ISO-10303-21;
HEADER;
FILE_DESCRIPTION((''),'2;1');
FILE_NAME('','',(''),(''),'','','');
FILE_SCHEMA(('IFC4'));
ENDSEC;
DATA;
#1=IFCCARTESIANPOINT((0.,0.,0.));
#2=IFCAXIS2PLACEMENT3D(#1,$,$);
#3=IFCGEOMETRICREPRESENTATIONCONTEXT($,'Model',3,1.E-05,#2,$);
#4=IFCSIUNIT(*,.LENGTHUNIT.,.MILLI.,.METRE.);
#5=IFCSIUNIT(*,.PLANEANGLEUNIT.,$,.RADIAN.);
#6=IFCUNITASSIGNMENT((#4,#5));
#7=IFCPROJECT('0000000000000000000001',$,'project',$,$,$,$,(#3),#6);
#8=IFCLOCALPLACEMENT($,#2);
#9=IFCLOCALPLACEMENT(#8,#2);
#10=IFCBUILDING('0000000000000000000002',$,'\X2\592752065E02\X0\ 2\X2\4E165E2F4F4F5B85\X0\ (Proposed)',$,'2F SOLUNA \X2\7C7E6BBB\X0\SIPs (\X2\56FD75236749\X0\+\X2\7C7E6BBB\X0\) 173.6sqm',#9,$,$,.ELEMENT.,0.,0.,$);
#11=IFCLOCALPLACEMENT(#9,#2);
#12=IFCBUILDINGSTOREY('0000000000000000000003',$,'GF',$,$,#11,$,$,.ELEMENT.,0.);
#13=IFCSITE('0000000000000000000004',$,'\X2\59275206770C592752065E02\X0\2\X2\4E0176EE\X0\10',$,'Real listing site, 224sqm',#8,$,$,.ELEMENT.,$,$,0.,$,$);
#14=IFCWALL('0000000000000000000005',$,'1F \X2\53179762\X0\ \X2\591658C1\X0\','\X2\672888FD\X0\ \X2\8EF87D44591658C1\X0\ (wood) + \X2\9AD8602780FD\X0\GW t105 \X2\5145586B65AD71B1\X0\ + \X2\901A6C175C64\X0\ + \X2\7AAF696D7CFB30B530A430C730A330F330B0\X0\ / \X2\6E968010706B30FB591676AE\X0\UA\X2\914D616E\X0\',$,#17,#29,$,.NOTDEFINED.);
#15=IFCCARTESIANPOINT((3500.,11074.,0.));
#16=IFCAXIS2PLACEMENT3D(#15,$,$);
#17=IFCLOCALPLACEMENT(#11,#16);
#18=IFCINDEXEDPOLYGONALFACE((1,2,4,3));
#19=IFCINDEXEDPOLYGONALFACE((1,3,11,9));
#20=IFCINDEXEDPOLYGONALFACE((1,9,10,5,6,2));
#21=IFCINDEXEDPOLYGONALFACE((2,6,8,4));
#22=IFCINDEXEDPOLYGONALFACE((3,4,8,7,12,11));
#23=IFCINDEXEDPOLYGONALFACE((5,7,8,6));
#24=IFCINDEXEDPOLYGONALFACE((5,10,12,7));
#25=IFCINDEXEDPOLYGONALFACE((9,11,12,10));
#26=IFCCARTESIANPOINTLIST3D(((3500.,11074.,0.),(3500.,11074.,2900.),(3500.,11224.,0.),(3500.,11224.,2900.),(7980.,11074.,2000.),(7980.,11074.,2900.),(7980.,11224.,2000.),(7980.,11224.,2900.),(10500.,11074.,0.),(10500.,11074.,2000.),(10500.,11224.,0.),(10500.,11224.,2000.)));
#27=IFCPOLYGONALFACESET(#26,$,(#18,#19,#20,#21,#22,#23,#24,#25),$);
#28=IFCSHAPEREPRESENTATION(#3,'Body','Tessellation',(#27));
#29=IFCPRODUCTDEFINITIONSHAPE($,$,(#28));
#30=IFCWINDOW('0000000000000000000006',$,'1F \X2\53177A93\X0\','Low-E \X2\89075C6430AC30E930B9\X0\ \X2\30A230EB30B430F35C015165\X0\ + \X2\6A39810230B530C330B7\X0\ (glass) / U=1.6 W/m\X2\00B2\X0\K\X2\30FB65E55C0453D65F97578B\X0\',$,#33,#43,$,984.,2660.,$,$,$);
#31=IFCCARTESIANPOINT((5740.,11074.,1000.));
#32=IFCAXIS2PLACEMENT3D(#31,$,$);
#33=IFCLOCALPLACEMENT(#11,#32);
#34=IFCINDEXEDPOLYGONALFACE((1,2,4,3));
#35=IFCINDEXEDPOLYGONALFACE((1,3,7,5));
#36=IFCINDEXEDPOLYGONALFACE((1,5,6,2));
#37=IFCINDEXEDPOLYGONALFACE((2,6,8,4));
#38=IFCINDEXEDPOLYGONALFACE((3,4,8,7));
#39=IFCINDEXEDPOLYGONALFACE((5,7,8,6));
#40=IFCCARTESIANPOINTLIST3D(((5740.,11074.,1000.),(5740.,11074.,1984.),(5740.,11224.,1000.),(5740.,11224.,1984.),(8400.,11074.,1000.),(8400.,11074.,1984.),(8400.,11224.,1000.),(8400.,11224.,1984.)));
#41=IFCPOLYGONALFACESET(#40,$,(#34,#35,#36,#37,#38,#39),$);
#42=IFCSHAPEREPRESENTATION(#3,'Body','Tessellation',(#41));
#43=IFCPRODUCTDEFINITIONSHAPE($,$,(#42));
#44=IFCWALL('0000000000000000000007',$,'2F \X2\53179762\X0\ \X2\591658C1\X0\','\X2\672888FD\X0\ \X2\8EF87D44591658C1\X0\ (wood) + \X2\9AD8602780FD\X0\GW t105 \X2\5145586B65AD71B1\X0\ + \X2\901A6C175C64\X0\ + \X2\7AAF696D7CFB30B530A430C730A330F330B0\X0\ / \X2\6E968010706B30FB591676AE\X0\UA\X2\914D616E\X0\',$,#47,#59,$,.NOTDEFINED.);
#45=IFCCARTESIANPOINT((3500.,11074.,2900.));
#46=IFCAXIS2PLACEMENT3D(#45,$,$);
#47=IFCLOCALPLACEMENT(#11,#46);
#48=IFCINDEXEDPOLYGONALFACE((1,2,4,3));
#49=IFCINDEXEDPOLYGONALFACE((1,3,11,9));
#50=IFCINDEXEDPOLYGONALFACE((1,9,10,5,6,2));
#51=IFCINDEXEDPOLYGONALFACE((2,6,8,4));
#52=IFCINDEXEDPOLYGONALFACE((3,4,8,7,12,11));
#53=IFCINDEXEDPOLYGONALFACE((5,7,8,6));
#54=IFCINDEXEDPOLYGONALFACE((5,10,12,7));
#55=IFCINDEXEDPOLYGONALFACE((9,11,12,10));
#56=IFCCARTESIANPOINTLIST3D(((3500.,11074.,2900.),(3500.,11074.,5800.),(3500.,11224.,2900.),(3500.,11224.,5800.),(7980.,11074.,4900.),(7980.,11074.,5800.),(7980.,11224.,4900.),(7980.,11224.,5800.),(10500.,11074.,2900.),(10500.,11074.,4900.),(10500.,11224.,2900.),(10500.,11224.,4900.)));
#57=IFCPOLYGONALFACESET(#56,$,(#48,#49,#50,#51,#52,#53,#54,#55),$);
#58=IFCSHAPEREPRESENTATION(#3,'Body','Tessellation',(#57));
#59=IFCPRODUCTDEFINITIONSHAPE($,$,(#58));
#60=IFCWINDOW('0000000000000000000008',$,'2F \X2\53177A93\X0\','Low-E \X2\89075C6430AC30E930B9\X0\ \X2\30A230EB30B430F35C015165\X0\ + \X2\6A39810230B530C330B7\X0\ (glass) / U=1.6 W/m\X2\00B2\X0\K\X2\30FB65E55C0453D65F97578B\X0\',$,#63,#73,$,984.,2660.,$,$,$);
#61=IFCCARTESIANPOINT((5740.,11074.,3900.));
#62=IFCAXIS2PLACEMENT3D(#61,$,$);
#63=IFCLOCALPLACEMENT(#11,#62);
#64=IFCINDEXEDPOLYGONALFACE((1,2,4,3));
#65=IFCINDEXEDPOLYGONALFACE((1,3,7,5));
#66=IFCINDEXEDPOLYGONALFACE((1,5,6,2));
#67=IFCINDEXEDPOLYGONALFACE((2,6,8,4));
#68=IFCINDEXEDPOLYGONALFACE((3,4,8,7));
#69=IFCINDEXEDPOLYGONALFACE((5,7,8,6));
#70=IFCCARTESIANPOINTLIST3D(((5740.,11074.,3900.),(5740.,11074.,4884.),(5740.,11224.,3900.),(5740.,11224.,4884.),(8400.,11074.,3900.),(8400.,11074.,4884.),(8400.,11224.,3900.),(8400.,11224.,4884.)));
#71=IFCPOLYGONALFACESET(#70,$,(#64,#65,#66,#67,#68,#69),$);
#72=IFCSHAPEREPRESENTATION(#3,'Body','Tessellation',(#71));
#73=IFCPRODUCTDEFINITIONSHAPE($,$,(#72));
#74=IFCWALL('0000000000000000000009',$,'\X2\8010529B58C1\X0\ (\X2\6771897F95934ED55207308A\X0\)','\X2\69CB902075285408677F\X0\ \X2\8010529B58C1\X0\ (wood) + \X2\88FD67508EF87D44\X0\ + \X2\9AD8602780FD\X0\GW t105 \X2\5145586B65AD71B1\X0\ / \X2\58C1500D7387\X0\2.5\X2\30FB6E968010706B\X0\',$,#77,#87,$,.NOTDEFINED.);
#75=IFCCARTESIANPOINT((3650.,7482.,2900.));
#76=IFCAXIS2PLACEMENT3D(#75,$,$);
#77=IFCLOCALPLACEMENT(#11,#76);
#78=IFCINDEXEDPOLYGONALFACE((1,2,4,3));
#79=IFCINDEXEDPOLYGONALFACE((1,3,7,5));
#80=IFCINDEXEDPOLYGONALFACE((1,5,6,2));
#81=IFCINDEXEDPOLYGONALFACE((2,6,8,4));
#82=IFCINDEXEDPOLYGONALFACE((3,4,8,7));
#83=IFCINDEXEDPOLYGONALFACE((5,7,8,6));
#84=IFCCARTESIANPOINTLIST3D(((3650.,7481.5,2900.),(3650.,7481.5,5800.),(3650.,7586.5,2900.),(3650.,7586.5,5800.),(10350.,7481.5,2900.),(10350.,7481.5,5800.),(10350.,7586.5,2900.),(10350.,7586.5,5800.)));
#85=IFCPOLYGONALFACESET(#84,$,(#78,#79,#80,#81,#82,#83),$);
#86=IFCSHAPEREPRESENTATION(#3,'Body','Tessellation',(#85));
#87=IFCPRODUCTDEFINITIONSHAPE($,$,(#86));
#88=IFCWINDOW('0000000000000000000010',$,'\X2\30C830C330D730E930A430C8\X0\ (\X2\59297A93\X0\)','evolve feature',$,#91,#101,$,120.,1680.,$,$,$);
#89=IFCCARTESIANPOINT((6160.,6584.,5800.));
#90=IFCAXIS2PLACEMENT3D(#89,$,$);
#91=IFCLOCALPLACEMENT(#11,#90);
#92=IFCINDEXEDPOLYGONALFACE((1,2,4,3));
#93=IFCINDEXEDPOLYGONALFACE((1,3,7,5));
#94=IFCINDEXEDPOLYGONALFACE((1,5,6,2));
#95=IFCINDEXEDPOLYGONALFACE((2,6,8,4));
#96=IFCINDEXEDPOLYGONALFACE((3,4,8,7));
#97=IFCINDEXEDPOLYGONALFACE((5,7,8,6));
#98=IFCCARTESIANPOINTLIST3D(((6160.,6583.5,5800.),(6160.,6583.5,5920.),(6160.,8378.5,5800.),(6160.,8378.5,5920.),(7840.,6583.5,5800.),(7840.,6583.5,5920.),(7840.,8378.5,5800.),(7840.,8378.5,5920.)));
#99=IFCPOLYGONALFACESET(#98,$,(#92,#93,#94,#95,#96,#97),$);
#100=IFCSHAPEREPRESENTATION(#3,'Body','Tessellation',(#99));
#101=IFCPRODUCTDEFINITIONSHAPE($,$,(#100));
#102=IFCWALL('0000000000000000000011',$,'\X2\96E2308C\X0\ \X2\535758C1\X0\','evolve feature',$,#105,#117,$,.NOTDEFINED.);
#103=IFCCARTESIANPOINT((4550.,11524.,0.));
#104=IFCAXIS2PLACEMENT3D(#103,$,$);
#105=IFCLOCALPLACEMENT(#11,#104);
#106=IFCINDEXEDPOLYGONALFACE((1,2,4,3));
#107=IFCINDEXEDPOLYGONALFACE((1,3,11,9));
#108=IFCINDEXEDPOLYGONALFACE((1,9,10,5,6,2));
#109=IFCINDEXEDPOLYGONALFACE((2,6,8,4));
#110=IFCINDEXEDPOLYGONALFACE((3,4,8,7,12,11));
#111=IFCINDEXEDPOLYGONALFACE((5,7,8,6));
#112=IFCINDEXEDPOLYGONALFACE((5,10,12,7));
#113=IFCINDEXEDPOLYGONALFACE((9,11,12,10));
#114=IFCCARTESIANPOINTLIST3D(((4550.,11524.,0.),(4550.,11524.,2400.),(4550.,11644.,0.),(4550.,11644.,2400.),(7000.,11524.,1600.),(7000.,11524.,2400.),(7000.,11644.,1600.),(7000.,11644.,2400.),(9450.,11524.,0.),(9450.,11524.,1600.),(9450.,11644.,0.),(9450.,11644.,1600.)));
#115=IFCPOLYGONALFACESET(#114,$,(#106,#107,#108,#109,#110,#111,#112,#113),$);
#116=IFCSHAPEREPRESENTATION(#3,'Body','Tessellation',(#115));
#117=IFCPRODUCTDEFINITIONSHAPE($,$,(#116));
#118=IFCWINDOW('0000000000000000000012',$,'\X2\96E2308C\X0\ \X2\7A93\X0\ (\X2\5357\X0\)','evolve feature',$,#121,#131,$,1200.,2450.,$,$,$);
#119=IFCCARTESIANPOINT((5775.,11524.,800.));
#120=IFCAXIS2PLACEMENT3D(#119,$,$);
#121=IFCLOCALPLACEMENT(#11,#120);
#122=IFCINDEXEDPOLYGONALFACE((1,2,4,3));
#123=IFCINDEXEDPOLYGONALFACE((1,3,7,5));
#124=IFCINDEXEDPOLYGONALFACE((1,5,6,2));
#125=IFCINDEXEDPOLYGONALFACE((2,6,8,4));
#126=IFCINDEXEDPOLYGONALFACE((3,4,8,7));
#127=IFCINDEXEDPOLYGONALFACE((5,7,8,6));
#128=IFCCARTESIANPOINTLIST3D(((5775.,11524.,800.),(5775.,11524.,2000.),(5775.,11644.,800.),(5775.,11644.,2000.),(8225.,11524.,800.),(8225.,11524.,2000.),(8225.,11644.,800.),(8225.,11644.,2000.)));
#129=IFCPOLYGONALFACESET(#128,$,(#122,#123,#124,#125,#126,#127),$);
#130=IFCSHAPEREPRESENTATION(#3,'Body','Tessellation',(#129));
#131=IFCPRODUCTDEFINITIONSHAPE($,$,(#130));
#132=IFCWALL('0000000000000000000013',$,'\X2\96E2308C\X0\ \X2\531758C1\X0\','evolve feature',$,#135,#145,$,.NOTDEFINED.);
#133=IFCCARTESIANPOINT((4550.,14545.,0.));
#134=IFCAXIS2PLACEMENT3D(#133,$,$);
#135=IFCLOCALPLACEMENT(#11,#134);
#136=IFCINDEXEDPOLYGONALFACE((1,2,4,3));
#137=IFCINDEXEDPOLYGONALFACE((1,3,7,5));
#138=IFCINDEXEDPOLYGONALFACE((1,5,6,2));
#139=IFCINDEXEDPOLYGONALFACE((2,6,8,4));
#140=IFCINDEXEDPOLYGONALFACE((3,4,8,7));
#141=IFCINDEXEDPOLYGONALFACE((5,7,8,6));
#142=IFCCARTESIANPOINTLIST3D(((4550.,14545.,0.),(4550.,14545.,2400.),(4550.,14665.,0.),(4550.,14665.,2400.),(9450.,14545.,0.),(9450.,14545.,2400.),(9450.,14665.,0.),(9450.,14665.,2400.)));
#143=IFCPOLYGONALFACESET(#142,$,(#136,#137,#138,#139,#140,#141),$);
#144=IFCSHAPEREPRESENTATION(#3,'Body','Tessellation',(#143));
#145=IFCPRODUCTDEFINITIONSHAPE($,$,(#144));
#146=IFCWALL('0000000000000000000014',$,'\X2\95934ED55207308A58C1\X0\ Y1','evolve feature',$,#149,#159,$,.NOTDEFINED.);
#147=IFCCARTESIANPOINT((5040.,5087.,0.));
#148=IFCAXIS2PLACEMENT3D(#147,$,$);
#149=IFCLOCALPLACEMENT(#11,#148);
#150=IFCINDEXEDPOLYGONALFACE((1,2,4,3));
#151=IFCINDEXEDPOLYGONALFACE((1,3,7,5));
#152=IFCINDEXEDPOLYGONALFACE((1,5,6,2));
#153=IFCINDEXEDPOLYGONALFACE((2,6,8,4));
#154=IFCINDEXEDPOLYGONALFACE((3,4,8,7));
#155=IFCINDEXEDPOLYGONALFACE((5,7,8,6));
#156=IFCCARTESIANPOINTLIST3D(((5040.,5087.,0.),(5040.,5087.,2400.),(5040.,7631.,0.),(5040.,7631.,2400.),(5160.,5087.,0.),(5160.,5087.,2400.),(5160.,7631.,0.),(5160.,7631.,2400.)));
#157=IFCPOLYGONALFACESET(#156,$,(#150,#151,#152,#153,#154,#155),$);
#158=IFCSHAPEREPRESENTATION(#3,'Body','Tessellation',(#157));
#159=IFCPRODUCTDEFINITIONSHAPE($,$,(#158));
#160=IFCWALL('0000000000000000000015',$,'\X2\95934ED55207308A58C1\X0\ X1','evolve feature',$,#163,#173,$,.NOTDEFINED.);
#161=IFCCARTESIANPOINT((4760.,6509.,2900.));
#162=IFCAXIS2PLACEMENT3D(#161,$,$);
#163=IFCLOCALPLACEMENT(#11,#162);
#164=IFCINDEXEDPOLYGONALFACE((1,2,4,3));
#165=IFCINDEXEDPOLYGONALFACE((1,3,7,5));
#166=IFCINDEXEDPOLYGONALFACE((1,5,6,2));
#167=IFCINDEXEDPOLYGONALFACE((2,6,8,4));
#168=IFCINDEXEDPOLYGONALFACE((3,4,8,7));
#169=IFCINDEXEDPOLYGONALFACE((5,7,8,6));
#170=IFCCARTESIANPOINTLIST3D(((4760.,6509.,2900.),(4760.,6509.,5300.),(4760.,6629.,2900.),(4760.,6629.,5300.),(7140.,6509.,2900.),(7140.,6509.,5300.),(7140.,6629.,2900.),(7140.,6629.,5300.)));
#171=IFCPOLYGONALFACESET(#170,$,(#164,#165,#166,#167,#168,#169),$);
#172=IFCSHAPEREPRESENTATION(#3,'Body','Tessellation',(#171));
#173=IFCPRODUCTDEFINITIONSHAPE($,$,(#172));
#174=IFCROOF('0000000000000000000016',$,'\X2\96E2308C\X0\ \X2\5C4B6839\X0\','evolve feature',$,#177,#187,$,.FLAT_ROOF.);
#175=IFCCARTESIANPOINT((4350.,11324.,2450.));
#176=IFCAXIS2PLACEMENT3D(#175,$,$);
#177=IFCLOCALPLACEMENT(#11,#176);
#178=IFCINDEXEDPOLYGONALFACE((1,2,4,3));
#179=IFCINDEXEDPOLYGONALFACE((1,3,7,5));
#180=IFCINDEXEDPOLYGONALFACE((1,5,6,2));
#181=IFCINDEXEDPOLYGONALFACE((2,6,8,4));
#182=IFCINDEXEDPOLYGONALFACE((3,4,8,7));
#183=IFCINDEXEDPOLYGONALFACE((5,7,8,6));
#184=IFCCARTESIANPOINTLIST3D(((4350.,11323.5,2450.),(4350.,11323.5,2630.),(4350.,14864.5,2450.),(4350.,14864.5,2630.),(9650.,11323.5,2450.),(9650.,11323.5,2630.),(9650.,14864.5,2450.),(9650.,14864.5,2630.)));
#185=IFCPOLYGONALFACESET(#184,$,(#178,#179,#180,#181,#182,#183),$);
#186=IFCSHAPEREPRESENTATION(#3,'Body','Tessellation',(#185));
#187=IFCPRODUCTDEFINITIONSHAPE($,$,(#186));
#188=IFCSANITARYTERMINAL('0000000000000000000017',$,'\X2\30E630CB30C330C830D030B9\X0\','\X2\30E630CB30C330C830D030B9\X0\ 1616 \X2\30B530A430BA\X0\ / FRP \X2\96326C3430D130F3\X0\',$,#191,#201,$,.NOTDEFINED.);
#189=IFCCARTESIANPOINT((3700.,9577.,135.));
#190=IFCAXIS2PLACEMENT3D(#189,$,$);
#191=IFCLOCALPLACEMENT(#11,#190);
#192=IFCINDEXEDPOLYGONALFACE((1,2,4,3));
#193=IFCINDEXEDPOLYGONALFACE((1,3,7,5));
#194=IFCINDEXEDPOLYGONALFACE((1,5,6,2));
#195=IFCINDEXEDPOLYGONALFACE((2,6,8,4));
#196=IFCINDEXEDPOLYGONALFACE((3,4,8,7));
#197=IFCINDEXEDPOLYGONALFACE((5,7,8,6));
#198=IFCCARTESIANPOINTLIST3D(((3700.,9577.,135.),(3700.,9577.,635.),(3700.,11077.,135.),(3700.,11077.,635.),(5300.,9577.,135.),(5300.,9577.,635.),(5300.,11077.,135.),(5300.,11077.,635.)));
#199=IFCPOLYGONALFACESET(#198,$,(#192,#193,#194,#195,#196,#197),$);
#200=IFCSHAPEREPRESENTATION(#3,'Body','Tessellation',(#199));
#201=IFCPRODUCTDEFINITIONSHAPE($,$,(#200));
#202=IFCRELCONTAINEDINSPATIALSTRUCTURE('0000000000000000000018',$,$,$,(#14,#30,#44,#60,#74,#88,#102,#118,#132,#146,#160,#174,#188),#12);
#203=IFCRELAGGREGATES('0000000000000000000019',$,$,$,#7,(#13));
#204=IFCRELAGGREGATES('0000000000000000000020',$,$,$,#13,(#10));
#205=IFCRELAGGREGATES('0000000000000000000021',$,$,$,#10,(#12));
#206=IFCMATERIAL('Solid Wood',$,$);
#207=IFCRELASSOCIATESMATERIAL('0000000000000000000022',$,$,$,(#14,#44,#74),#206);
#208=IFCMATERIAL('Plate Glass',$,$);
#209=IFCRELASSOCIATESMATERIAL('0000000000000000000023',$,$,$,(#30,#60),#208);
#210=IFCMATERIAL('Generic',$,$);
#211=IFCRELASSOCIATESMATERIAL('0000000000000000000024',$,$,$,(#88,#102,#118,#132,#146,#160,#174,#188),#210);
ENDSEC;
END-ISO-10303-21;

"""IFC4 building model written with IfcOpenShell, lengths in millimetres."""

from ifc_helpers import new_model, si_unit, frame, frame_2d, origin, place, context, project, spatial, rectangle, extrude, material, element, fill, save


model = new_model("IFC4")

# Units and contexts
model_context = context("Model", 3, precision=1e-05, world=origin())
ifc_project = project(units=[si_unit("LENGTHUNIT", "METRE", prefix="MILLI"), si_unit("PLANEANGLEUNIT", "RADIAN")], contexts=[model_context])

# Site, building, storey
site_placement = place(None, origin())
site = spatial("IfcSite", under=ifc_project, at=site_placement, Name="大分県大分市2丁目10", ObjectType="Real listing site, 224sqm", CompositionType="ELEMENT", RefElevation=0.0)
building_placement = place(site_placement, origin())
building = spatial("IfcBuilding", under=site, at=building_placement, Name="大分市 2世帯住宅 (Proposed)", ObjectType="2F SOLUNA 籾殻SIPs (国産杉+籾殻) 173.6sqm", CompositionType="ELEMENT", ElevationOfRefHeight=0.0, ElevationOfTerrain=0.0)
storey_placement = place(building_placement, origin())
storey = spatial("IfcBuildingStorey", under=building, at=storey_placement, Name="GF", CompositionType="ELEMENT", Elevation=0.0)

# Shared definitions
ifc_material_1 = material(Name="Generic")

# Wall, opening, window
ifc_material_2 = material(Name="Solid Wood")
wall_1_placement = place(storey_placement, frame((3500.0, 11074.0, 0.0)))
wall_1 = element("IfcWall", 1, at=wall_1_placement, inside=storey, material=ifc_material_2, Name="1F 北面 外壁", Description="木製 軸組外壁 (wood) + 高性能GW t105 充填断熱 + 通気層 + 窯業系サイディング / 準耐火・外皮UA配慮", PredefinedType="NOTDEFINED", context=model_context, shape_type="SweptSolid", body=[
    extrude(rectangle(XDim=7000.0, YDim=150.0, at=frame_2d((3500.0, 75.0))), frame((3500.0, 11074.0, 0.0)), (0.0, 0.0, 1.0), 2900.0),
])
opening_1_placement = place(storey_placement, frame((5740.0, 11074.0, 1000.0)))
opening_1 = element("IfcOpeningElement", 2, at=opening_1_placement, cuts=wall_1, PredefinedType="NOTDEFINED", context=model_context, shape_type="SweptSolid", body=[
    extrude(rectangle(XDim=2660.0, YDim=150.0, at=frame_2d((1330.0, 75.0))), frame((5740.0, 11074.0, 1000.0)), (0.0, 0.0, 1.0), 984.0),
])
ifc_material_3 = material(Name="Plate Glass")
window_1_placement = place(storey_placement, frame((5740.0, 11074.0, 1000.0)))
window_1 = element("IfcWindow", 3, at=window_1_placement, inside=storey, material=ifc_material_3, Name="1F 北窓", Description="Low-E 複層ガラス アルゴン封入 + 樹脂サッシ (glass) / U=1.6 W/m²K・日射取得型", OverallHeight=984.0, OverallWidth=2660.0, context=model_context, shape_type="SweptSolid", body=[
    extrude(rectangle(XDim=2660.0, YDim=150.0, at=frame_2d((1330.0, 75.0))), frame((5740.0, 11074.0, 1000.0)), (0.0, 0.0, 1.0), 984.0),
])
fill(opening_1, window_1)

# Wall, opening, window
wall_2_placement = place(storey_placement, frame((3500.0, 11074.0, 2900.0)))
wall_2 = element("IfcWall", 4, at=wall_2_placement, inside=storey, material=ifc_material_2, Name="2F 北面 外壁", Description="木製 軸組外壁 (wood) + 高性能GW t105 充填断熱 + 通気層 + 窯業系サイディング / 準耐火・外皮UA配慮", PredefinedType="NOTDEFINED", context=model_context, shape_type="SweptSolid", body=[
    extrude(rectangle(XDim=7000.0, YDim=150.0, at=frame_2d((3500.0, 75.0))), frame((3500.0, 11074.0, 2900.0)), (0.0, 0.0, 1.0), 2900.0),
])
opening_2_placement = place(storey_placement, frame((5740.0, 11074.0, 3900.0)))
opening_2 = element("IfcOpeningElement", 5, at=opening_2_placement, cuts=wall_2, PredefinedType="NOTDEFINED", context=model_context, shape_type="SweptSolid", body=[
    extrude(rectangle(XDim=2660.0, YDim=150.0, at=frame_2d((1330.0, 75.0))), frame((5740.0, 11074.0, 3900.0)), (0.0, 0.0, 1.0), 984.0),
])
window_2_placement = place(storey_placement, frame((5740.0, 11074.0, 3900.0)))
window_2 = element("IfcWindow", 6, at=window_2_placement, inside=storey, material=ifc_material_3, Name="2F 北窓", Description="Low-E 複層ガラス アルゴン封入 + 樹脂サッシ (glass) / U=1.6 W/m²K・日射取得型", OverallHeight=984.0, OverallWidth=2660.0, context=model_context, shape_type="SweptSolid", body=[
    extrude(rectangle(XDim=2660.0, YDim=150.0, at=frame_2d((1330.0, 75.0))), frame((5740.0, 11074.0, 3900.0)), (0.0, 0.0, 1.0), 984.0),
])
fill(opening_2, window_2)

# Wall
wall_3_placement = place(storey_placement, frame((3650.0, 7482.0, 2900.0)))
element("IfcWall", 7, at=wall_3_placement, inside=storey, material=ifc_material_2, Name="耐力壁 (東西間仕切り)", Description="構造用合板 耐力壁 (wood) + 製材軸組 + 高性能GW t105 充填断熱 / 壁倍率2.5・準耐火", PredefinedType="NOTDEFINED", context=model_context, shape_type="SweptSolid", body=[
    extrude(rectangle(XDim=6700.0, YDim=105.0, at=frame_2d((3350.0, 52.0))), frame((3650.0, 7482.0, 2900.0)), (0.0, 0.0, 1.0), 2900.0),
])

# Window
window_3_placement = place(storey_placement, frame((6160.0, 6584.0, 5800.0)))
element("IfcWindow", 8, at=window_3_placement, inside=storey, material=ifc_material_1, Name="トップライト (天窓)", Description="evolve feature", OverallHeight=120.0, OverallWidth=1680.0, context=model_context, shape_type="SweptSolid", body=[
    extrude(rectangle(XDim=1680.0, YDim=1795.0, at=frame_2d((840.0, 897.0))), frame((6160.0, 6584.0, 5800.0)), (0.0, 0.0, 1.0), 120.0),
])

# Wall, opening, window
wall_4_placement = place(storey_placement, frame((4550.0, 11524.0, 0.0)))
wall_4 = element("IfcWall", 9, at=wall_4_placement, inside=storey, material=ifc_material_1, Name="離れ 南壁", Description="evolve feature", PredefinedType="NOTDEFINED", context=model_context, shape_type="SweptSolid", body=[
    extrude(rectangle(XDim=4900.0, YDim=120.0, at=frame_2d((2450.0, 60.0))), frame((4550.0, 11524.0, 0.0)), (0.0, 0.0, 1.0), 2400.0),
])
opening_3_placement = place(storey_placement, frame((5775.0, 11524.0, 800.0)))
opening_3 = element("IfcOpeningElement", 10, at=opening_3_placement, cuts=wall_4, PredefinedType="NOTDEFINED", context=model_context, shape_type="SweptSolid", body=[
    extrude(rectangle(XDim=2450.0, YDim=120.0, at=frame_2d((1225.0, 60.0))), frame((5775.0, 11524.0, 800.0)), (0.0, 0.0, 1.0), 1200.0),
])
window_4_placement = place(storey_placement, frame((5775.0, 11524.0, 800.0)))
window_4 = element("IfcWindow", 11, at=window_4_placement, inside=storey, material=ifc_material_1, Name="離れ 窓 (南)", Description="evolve feature", OverallHeight=1200.0, OverallWidth=2450.0, context=model_context, shape_type="SweptSolid", body=[
    extrude(rectangle(XDim=2450.0, YDim=120.0, at=frame_2d((1225.0, 60.0))), frame((5775.0, 11524.0, 800.0)), (0.0, 0.0, 1.0), 1200.0),
])
fill(opening_3, window_4)

# Walls
wall_5_placement = place(storey_placement, frame((4550.0, 14545.0, 0.0)))
element("IfcWall", 12, at=wall_5_placement, inside=storey, material=ifc_material_1, Name="離れ 北壁", Description="evolve feature", PredefinedType="NOTDEFINED", context=model_context, shape_type="SweptSolid", body=[
    extrude(rectangle(XDim=4900.0, YDim=120.0, at=frame_2d((2450.0, 60.0))), frame((4550.0, 14545.0, 0.0)), (0.0, 0.0, 1.0), 2400.0),
])
wall_6_placement = place(storey_placement, frame((5040.0, 5087.0, 0.0)))
element("IfcWall", 13, at=wall_6_placement, inside=storey, material=ifc_material_1, Name="間仕切り壁 Y1", Description="evolve feature", PredefinedType="NOTDEFINED", context=model_context, shape_type="SweptSolid", body=[
    extrude(rectangle(XDim=120.0, YDim=2544.0, at=frame_2d((60.0, 1272.0))), frame((5040.0, 5087.0, 0.0)), (0.0, 0.0, 1.0), 2400.0),
])
wall_7_placement = place(storey_placement, frame((4760.0, 6509.0, 2900.0)))
element("IfcWall", 14, at=wall_7_placement, inside=storey, material=ifc_material_1, Name="間仕切り壁 X1", Description="evolve feature", PredefinedType="NOTDEFINED", context=model_context, shape_type="SweptSolid", body=[
    extrude(rectangle(XDim=2380.0, YDim=120.0, at=frame_2d((1190.0, 60.0))), frame((4760.0, 6509.0, 2900.0)), (0.0, 0.0, 1.0), 2400.0),
])

# Roof
roof_placement = place(storey_placement, frame((4350.0, 11324.0, 2450.0)))
element("IfcRoof", 15, at=roof_placement, inside=storey, material=ifc_material_1, Name="離れ 屋根", Description="evolve feature", PredefinedType="FLAT_ROOF", context=model_context, shape_type="SweptSolid", body=[
    extrude(rectangle(XDim=5300.0, YDim=3541.0, at=frame_2d((2650.0, 1770.0))), frame((4350.0, 11324.0, 2450.0)), (0.0, 0.0, 1.0), 180.0),
])

# Sanitary terminal
sanitary_terminal_1_placement = place(storey_placement, frame((3700.0, 9577.0, 135.0)))
element("IfcSanitaryTerminal", 16, at=sanitary_terminal_1_placement, inside=storey, material=ifc_material_1, Name="ユニットバス", Description="ユニットバス 1616 サイズ / FRP 防水パン", PredefinedType="NOTDEFINED", context=model_context, shape_type="SweptSolid", body=[
    extrude(rectangle(XDim=1600.0, YDim=1500.0, at=frame_2d((800.0, 750.0))), frame((3700.0, 9577.0, 135.0)), (0.0, 0.0, 1.0), 500.0),
])

save(model, "model.ifc")
